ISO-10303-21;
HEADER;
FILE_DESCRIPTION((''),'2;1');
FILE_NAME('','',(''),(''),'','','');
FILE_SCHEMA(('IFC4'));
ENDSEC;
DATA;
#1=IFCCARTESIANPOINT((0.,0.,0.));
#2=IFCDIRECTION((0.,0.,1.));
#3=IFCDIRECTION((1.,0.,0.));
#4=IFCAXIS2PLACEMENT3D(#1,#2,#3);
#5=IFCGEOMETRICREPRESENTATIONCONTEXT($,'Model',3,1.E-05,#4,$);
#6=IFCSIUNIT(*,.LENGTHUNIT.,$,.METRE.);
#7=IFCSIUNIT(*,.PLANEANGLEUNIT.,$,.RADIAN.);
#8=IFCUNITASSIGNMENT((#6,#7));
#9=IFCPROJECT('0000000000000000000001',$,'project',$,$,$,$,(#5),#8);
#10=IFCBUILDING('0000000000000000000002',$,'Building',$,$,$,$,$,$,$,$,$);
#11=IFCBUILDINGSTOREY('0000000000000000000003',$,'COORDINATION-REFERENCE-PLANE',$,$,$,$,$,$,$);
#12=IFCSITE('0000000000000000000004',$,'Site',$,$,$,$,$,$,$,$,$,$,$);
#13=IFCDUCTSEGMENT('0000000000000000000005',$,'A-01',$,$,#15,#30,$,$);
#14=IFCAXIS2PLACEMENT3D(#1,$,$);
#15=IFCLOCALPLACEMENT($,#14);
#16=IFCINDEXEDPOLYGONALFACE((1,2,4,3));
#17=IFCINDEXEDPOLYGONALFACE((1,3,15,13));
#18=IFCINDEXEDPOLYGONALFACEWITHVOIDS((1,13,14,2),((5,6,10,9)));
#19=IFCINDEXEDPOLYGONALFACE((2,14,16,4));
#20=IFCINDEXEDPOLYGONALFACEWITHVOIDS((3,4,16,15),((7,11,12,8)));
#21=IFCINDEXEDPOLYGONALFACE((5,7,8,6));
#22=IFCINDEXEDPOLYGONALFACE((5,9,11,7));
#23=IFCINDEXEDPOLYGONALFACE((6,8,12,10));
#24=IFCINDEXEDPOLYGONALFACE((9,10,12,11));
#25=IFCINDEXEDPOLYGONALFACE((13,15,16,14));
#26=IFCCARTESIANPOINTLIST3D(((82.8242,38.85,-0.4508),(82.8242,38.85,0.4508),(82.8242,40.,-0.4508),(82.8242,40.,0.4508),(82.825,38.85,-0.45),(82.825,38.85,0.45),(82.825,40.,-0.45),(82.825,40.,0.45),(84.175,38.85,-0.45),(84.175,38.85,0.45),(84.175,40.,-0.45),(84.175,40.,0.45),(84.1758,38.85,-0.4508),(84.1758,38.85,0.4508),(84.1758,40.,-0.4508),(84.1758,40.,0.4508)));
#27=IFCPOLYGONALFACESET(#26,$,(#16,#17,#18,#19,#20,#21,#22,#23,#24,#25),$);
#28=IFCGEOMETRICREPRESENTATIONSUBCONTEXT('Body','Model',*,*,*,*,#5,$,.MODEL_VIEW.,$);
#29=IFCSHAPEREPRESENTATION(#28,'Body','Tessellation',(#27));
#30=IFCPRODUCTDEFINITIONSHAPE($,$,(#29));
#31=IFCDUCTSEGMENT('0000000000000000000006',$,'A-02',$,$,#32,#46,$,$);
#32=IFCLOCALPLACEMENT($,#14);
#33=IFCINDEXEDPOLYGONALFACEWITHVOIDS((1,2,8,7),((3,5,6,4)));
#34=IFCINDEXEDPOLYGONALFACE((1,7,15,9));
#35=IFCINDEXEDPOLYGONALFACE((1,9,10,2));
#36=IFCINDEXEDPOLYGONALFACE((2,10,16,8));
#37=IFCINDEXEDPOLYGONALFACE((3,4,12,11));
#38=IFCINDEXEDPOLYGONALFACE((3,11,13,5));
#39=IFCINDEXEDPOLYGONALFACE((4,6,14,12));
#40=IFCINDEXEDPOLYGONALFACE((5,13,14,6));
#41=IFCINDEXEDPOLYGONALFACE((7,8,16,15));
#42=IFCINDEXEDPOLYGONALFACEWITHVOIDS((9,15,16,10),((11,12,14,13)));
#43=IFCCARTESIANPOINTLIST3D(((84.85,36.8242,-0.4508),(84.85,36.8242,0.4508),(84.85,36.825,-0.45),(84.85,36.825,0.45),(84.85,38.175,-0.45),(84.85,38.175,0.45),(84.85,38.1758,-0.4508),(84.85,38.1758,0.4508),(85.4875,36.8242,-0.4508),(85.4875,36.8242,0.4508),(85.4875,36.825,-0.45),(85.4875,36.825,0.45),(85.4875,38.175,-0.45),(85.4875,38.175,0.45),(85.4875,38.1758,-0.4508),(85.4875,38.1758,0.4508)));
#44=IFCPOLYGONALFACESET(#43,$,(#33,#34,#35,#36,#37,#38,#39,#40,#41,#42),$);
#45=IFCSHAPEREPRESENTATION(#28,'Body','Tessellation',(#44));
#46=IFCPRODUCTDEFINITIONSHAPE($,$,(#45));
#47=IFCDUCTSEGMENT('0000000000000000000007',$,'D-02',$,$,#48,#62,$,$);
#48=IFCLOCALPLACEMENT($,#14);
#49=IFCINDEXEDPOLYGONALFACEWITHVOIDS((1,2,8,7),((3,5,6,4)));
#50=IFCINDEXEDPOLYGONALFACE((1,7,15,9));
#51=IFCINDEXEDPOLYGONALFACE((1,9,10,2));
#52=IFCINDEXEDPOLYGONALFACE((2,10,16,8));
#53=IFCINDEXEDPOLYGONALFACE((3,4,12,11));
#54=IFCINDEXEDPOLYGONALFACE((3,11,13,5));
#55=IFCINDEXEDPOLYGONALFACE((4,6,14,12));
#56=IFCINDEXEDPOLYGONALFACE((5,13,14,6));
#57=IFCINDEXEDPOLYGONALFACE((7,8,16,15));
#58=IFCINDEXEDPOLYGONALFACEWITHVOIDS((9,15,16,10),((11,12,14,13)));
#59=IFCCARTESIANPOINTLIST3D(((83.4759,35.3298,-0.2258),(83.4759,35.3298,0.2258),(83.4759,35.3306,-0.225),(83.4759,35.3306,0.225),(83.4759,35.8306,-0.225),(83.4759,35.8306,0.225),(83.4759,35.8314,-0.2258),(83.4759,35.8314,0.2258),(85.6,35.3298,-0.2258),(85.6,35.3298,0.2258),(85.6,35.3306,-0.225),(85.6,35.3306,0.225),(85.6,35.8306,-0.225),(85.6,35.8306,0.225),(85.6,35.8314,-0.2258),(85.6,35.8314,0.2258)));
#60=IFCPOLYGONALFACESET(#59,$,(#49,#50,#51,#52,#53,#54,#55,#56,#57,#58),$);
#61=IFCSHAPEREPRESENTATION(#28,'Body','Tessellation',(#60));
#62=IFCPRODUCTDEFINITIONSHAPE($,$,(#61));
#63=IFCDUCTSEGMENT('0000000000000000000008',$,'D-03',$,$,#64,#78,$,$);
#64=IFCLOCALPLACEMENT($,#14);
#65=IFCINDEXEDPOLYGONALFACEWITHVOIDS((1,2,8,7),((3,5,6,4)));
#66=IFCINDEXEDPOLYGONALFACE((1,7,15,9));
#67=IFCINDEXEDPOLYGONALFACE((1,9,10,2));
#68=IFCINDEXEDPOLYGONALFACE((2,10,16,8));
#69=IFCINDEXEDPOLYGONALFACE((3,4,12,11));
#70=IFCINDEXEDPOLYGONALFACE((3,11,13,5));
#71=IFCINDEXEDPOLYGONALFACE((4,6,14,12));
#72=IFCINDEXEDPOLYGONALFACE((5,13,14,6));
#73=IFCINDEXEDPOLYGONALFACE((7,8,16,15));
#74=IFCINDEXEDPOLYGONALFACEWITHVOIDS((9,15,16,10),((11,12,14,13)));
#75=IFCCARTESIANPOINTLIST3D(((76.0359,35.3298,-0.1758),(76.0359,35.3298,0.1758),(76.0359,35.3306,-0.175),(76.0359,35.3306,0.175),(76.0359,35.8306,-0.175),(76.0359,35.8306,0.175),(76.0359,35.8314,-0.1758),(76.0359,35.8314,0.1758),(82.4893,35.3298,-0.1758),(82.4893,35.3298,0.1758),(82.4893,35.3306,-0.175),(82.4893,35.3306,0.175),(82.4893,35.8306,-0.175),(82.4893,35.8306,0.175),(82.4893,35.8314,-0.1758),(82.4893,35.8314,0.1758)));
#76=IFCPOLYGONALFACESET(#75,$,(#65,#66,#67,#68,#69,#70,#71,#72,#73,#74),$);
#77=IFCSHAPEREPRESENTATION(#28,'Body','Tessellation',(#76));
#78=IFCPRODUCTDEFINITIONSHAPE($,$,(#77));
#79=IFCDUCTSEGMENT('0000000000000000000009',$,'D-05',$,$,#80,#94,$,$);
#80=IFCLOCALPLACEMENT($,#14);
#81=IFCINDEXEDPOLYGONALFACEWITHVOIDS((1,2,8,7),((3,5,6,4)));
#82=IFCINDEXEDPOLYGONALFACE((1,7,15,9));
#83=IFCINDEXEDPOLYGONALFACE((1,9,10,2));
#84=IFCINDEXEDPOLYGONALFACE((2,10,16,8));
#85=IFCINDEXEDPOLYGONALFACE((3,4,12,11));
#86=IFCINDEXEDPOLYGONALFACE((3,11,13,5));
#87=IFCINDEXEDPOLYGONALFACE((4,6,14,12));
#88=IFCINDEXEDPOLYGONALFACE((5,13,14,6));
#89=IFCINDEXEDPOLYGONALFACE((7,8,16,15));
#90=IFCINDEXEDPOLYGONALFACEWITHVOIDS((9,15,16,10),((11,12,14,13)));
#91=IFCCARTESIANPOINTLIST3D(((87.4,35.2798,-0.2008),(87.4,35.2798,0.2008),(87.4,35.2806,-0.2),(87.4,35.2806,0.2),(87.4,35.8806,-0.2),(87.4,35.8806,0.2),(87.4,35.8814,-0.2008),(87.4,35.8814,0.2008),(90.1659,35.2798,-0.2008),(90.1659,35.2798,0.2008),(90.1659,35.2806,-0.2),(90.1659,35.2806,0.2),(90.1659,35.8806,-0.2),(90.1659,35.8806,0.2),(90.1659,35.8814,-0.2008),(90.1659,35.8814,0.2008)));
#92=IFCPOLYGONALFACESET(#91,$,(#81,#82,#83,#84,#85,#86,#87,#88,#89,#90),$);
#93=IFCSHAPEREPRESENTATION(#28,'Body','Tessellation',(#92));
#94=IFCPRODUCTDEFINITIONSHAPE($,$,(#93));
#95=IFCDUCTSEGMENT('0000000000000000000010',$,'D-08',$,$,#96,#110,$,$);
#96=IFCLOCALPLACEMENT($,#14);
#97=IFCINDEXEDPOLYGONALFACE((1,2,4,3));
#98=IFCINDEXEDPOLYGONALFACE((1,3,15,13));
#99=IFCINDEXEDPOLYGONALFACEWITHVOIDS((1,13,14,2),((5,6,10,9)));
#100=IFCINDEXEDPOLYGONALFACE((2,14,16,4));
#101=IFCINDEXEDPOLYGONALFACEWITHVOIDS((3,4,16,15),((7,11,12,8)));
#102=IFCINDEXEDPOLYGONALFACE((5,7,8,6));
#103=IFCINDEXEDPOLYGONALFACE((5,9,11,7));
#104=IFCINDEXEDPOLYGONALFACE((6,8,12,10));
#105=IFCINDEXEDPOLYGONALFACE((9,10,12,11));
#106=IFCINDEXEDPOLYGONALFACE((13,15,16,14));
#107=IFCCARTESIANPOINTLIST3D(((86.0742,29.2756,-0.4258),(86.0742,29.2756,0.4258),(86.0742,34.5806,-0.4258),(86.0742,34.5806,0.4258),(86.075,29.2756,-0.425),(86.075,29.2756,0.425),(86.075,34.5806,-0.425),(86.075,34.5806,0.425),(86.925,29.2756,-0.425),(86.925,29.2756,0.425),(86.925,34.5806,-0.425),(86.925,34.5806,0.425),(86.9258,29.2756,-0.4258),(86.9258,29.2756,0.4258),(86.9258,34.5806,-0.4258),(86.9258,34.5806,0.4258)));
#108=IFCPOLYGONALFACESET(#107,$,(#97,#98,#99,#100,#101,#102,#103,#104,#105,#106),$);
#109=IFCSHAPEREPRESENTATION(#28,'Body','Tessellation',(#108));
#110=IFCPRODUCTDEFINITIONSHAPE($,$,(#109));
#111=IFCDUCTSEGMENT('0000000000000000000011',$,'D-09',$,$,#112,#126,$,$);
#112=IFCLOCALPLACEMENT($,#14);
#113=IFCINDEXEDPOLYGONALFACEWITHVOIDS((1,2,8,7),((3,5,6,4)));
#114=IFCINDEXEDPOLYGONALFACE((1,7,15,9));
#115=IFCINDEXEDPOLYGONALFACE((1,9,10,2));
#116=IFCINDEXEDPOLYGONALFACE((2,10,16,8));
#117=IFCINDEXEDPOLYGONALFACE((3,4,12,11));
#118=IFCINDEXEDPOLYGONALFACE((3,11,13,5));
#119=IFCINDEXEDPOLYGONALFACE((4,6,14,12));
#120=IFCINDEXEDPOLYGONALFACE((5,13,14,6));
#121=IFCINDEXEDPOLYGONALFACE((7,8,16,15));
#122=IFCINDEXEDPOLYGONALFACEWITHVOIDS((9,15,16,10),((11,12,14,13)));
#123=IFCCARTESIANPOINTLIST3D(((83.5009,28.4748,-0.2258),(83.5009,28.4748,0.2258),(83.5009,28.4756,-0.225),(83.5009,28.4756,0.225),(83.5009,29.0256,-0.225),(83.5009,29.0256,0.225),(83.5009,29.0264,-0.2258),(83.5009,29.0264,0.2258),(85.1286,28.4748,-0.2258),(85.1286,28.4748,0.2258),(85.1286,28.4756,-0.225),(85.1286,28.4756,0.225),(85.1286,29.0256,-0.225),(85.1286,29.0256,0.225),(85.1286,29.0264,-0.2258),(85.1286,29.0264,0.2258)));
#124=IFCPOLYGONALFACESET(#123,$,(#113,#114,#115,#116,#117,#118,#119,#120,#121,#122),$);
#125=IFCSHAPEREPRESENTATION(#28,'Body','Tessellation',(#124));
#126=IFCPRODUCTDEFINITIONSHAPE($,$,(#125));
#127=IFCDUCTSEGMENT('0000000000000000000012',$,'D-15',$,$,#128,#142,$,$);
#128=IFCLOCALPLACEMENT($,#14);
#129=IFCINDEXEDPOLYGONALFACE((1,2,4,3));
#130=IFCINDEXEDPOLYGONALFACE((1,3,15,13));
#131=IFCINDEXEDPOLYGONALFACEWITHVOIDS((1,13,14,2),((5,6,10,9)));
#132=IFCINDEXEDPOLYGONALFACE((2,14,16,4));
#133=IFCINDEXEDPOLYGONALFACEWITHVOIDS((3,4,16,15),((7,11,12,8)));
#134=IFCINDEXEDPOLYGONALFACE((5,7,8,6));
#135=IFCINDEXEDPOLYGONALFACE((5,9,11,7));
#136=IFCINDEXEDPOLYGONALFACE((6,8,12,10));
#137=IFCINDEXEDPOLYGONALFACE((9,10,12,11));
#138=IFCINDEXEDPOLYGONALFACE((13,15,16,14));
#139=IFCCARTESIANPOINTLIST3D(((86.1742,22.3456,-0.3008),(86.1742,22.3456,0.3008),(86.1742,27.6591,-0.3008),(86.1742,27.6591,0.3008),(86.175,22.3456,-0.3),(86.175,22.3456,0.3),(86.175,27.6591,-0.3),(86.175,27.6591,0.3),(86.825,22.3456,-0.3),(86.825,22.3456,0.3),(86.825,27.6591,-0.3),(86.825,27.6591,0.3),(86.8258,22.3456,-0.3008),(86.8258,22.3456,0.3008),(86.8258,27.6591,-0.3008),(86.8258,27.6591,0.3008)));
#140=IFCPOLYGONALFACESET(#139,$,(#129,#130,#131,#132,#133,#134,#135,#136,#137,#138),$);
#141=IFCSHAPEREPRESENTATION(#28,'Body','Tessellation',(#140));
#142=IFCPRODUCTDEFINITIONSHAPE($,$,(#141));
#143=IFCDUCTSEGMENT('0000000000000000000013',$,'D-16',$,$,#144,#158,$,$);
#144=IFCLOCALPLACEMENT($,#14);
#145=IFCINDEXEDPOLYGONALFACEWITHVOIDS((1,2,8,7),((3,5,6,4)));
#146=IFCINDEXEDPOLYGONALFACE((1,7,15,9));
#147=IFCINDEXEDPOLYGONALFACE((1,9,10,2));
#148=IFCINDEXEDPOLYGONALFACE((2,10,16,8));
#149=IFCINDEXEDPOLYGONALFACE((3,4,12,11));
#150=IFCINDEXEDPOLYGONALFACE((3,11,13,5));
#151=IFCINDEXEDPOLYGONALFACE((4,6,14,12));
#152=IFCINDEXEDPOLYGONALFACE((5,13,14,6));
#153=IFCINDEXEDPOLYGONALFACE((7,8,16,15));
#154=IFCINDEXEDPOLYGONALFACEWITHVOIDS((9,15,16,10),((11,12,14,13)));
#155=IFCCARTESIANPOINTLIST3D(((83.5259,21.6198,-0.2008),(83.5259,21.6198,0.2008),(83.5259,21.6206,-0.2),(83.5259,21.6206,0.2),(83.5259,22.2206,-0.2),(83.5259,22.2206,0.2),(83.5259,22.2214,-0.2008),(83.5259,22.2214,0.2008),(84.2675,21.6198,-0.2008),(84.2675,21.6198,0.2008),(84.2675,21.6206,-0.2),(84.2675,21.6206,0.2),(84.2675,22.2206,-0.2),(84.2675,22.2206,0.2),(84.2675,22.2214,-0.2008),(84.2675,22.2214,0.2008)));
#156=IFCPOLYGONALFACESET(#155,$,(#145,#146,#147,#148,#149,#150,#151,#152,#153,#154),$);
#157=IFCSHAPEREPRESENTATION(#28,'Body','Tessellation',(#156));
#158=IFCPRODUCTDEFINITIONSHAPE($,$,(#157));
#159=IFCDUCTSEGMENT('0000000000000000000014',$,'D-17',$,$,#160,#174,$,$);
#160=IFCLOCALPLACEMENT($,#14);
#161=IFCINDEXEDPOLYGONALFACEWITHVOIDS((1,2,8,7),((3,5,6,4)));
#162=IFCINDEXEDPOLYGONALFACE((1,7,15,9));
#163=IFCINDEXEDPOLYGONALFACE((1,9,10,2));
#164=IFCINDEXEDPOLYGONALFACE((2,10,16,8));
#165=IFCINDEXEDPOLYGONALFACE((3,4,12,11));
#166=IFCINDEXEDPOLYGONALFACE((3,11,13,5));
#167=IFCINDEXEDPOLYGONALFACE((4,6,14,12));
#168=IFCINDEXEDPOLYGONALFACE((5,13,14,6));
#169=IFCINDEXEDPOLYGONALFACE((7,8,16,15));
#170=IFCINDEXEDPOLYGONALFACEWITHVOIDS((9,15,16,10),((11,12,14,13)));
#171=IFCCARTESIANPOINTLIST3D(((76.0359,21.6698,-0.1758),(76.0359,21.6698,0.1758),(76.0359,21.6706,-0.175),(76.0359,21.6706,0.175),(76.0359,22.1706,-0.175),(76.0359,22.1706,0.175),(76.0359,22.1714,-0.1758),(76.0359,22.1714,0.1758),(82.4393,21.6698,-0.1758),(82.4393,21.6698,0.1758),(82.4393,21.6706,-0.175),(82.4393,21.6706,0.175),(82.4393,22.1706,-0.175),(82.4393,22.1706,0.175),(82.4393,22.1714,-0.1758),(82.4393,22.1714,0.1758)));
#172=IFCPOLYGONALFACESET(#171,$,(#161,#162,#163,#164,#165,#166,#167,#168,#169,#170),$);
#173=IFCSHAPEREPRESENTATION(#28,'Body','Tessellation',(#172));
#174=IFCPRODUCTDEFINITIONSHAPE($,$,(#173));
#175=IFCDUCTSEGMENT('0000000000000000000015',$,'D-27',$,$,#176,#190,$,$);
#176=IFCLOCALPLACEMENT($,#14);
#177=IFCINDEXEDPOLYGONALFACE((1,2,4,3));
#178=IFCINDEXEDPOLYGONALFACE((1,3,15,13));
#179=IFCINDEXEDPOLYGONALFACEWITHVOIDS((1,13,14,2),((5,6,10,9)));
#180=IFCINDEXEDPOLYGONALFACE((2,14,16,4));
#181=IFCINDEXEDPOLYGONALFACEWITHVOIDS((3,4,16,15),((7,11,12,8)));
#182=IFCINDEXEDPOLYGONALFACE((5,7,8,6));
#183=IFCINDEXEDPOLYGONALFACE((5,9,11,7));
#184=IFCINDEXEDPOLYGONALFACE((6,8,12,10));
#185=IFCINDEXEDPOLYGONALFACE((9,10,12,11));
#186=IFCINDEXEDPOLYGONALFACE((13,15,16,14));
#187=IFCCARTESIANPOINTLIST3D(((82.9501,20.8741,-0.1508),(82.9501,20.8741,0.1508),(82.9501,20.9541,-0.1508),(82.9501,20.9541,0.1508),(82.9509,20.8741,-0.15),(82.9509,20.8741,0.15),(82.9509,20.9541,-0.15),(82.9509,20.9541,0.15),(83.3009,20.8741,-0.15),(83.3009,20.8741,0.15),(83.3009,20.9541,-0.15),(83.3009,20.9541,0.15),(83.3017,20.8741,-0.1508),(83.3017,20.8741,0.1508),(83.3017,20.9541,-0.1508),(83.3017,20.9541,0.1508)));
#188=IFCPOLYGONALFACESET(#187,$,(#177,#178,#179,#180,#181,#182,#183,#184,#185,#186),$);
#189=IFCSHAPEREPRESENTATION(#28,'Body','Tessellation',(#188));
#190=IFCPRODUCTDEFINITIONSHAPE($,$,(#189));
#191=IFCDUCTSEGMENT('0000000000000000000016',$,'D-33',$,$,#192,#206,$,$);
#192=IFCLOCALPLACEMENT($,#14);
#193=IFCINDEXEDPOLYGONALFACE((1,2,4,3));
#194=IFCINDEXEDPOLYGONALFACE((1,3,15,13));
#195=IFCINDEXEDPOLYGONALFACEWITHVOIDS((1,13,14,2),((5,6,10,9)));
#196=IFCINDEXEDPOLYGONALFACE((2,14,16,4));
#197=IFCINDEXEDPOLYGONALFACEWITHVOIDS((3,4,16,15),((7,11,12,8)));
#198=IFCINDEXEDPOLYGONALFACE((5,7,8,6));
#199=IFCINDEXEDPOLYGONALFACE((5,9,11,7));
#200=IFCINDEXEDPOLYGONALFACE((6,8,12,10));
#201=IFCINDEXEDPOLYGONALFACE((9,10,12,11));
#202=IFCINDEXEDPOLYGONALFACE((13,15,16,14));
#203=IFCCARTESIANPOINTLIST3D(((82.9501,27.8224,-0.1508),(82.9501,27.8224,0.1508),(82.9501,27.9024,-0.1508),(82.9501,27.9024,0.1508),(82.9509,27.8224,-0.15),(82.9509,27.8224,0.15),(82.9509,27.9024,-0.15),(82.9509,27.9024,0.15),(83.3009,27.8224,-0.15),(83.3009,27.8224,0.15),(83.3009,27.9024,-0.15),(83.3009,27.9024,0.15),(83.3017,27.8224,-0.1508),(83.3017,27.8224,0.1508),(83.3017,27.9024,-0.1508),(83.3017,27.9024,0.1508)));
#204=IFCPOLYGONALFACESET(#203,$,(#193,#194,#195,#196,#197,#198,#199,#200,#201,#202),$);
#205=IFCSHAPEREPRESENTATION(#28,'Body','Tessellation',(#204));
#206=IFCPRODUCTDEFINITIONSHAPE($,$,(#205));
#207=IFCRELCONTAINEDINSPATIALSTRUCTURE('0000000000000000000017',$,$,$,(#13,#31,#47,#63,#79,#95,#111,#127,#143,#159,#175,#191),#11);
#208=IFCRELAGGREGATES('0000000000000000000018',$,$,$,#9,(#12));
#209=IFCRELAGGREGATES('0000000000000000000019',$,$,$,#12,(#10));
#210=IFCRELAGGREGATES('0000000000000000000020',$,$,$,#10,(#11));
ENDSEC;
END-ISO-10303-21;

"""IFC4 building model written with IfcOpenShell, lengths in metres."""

from ifc_helpers import new_model, si_unit, frame, origin, origin_with_axes, place, context, subcontext, project, spatial, hollow_rectangle, extrude, element, save


model = new_model("IFC4")

# Units and contexts
model_context = context("Model", 3, precision=1e-05, world=origin_with_axes())
body_context_1 = subcontext(model_context, "Body", "Model", "MODEL_VIEW")
ifc_project = project(units=[si_unit("LENGTHUNIT", "METRE"), si_unit("PLANEANGLEUNIT", "RADIAN")], contexts=[model_context])

# Site, building, storey
site = spatial("IfcSite", under=ifc_project, Name="Site")
building = spatial("IfcBuilding", under=site, Name="Building")
storey = spatial("IfcBuildingStorey", under=building, Name="COORDINATION-REFERENCE-PLANE")

# Duct segments
duct_segment_1_placement = place(None, frame((83.5, 38.85, 0.0), z_axis=(0.0, 1.0, 0.0), x_axis=(1.0, 0.0, 0.0)))
element("IfcDuctSegment", 1, at=duct_segment_1_placement, inside=storey, Name="A-01", context=body_context_1, shape_type="SweptSolid", body=[
    extrude(hollow_rectangle(XDim=1.3516, YDim=0.9016, WallThickness=0.0008), origin(), (0.0, 0.0, 1.0), 1.15),
])
duct_segment_2_placement = place(None, frame((84.85, 37.5, 0.0), z_axis=(1.0, 0.0, 0.0), x_axis=(0.0, 1.0, 0.0)))
element("IfcDuctSegment", 2, at=duct_segment_2_placement, inside=storey, Name="A-02", context=body_context_1, shape_type="SweptSolid", body=[
    extrude(hollow_rectangle(XDim=1.3516, YDim=0.9016, WallThickness=0.0008), origin(), (0.0, 0.0, 1.0), 0.6375),
])
duct_segment_3_placement = place(None, frame((83.4759, 35.5806, 0.0), z_axis=(1.0, 0.0, 0.0), x_axis=(0.0, 1.0, 0.0)))
element("IfcDuctSegment", 3, at=duct_segment_3_placement, inside=storey, Name="D-02", context=body_context_1, shape_type="SweptSolid", body=[
    extrude(hollow_rectangle(XDim=0.5016, YDim=0.4516, WallThickness=0.0008), origin(), (0.0, 0.0, 1.0), 2.1241),
])
duct_segment_4_placement = place(None, frame((76.0359, 35.5806, 0.0), z_axis=(1.0, 0.0, 0.0), x_axis=(0.0, 1.0, 0.0)))
element("IfcDuctSegment", 4, at=duct_segment_4_placement, inside=storey, Name="D-03", context=body_context_1, shape_type="SweptSolid", body=[
    extrude(hollow_rectangle(XDim=0.5016, YDim=0.3516, WallThickness=0.0008), origin(), (0.0, 0.0, 1.0), 6.4534),
])
duct_segment_5_placement = place(None, frame((87.4, 35.5806, 0.0), z_axis=(1.0, 0.0, 0.0), x_axis=(0.0, 1.0, 0.0)))
element("IfcDuctSegment", 5, at=duct_segment_5_placement, inside=storey, Name="D-05", context=body_context_1, shape_type="SweptSolid", body=[
    extrude(hollow_rectangle(XDim=0.6016, YDim=0.4016, WallThickness=0.0008), origin(), (0.0, 0.0, 1.0), 2.7659),
])
duct_segment_6_placement = place(None, frame((86.5, 29.2756, 0.0), z_axis=(0.0, 1.0, 0.0), x_axis=(1.0, 0.0, 0.0)))
element("IfcDuctSegment", 6, at=duct_segment_6_placement, inside=storey, Name="D-08", context=body_context_1, shape_type="SweptSolid", body=[
    extrude(hollow_rectangle(XDim=0.8516, YDim=0.8516, WallThickness=0.0008), origin(), (0.0, 0.0, 1.0), 5.305),
])
duct_segment_7_placement = place(None, frame((83.5009, 28.7506, 0.0), z_axis=(1.0, 0.0, 0.0), x_axis=(0.0, 1.0, 0.0)))
element("IfcDuctSegment", 7, at=duct_segment_7_placement, inside=storey, Name="D-09", context=body_context_1, shape_type="SweptSolid", body=[
    extrude(hollow_rectangle(XDim=0.5516, YDim=0.4516, WallThickness=0.0008), origin(), (0.0, 0.0, 1.0), 1.6277),
])
duct_segment_8_placement = place(None, frame((86.5, 22.3456, 0.0), z_axis=(0.0, 1.0, 0.0), x_axis=(1.0, 0.0, 0.0)))
element("IfcDuctSegment", 8, at=duct_segment_8_placement, inside=storey, Name="D-15", context=body_context_1, shape_type="SweptSolid", body=[
    extrude(hollow_rectangle(XDim=0.6516, YDim=0.6016, WallThickness=0.0008), origin(), (0.0, 0.0, 1.0), 5.3135),
])
duct_segment_9_placement = place(None, frame((83.5259, 21.9206, 0.0), z_axis=(1.0, 0.0, 0.0), x_axis=(0.0, 1.0, 0.0)))
element("IfcDuctSegment", 9, at=duct_segment_9_placement, inside=storey, Name="D-16", context=body_context_1, shape_type="SweptSolid", body=[
    extrude(hollow_rectangle(XDim=0.6016, YDim=0.4016, WallThickness=0.0008), origin(), (0.0, 0.0, 1.0), 0.7416),
])
duct_segment_10_placement = place(None, frame((76.0359, 21.9206, 0.0), z_axis=(1.0, 0.0, 0.0), x_axis=(0.0, 1.0, 0.0)))
element("IfcDuctSegment", 10, at=duct_segment_10_placement, inside=storey, Name="D-17", context=body_context_1, shape_type="SweptSolid", body=[
    extrude(hollow_rectangle(XDim=0.5016, YDim=0.3516, WallThickness=0.0008), origin(), (0.0, 0.0, 1.0), 6.4034),
])
for number, where, z_axis, x_axis, name in (
    (11, (83.1259, 20.8741, 0.0), (0.0, 1.0, 0.0), (1.0, 0.0, 0.0), "D-27"),
    (12, (83.1259, 27.8224, 0.0), (0.0, 1.0, 0.0), (1.0, 0.0, 0.0), "D-33"),
):
    element("IfcDuctSegment", number, at=place(None, frame(where, z_axis=z_axis, x_axis=x_axis)), inside=storey, Name=name, context=body_context_1, shape_type="SweptSolid", body=[
        extrude(hollow_rectangle(XDim=0.3516, YDim=0.3016, WallThickness=0.0008), origin(), (0.0, 0.0, 1.0), 0.08),
    ])

save(model, "model.ifc")
